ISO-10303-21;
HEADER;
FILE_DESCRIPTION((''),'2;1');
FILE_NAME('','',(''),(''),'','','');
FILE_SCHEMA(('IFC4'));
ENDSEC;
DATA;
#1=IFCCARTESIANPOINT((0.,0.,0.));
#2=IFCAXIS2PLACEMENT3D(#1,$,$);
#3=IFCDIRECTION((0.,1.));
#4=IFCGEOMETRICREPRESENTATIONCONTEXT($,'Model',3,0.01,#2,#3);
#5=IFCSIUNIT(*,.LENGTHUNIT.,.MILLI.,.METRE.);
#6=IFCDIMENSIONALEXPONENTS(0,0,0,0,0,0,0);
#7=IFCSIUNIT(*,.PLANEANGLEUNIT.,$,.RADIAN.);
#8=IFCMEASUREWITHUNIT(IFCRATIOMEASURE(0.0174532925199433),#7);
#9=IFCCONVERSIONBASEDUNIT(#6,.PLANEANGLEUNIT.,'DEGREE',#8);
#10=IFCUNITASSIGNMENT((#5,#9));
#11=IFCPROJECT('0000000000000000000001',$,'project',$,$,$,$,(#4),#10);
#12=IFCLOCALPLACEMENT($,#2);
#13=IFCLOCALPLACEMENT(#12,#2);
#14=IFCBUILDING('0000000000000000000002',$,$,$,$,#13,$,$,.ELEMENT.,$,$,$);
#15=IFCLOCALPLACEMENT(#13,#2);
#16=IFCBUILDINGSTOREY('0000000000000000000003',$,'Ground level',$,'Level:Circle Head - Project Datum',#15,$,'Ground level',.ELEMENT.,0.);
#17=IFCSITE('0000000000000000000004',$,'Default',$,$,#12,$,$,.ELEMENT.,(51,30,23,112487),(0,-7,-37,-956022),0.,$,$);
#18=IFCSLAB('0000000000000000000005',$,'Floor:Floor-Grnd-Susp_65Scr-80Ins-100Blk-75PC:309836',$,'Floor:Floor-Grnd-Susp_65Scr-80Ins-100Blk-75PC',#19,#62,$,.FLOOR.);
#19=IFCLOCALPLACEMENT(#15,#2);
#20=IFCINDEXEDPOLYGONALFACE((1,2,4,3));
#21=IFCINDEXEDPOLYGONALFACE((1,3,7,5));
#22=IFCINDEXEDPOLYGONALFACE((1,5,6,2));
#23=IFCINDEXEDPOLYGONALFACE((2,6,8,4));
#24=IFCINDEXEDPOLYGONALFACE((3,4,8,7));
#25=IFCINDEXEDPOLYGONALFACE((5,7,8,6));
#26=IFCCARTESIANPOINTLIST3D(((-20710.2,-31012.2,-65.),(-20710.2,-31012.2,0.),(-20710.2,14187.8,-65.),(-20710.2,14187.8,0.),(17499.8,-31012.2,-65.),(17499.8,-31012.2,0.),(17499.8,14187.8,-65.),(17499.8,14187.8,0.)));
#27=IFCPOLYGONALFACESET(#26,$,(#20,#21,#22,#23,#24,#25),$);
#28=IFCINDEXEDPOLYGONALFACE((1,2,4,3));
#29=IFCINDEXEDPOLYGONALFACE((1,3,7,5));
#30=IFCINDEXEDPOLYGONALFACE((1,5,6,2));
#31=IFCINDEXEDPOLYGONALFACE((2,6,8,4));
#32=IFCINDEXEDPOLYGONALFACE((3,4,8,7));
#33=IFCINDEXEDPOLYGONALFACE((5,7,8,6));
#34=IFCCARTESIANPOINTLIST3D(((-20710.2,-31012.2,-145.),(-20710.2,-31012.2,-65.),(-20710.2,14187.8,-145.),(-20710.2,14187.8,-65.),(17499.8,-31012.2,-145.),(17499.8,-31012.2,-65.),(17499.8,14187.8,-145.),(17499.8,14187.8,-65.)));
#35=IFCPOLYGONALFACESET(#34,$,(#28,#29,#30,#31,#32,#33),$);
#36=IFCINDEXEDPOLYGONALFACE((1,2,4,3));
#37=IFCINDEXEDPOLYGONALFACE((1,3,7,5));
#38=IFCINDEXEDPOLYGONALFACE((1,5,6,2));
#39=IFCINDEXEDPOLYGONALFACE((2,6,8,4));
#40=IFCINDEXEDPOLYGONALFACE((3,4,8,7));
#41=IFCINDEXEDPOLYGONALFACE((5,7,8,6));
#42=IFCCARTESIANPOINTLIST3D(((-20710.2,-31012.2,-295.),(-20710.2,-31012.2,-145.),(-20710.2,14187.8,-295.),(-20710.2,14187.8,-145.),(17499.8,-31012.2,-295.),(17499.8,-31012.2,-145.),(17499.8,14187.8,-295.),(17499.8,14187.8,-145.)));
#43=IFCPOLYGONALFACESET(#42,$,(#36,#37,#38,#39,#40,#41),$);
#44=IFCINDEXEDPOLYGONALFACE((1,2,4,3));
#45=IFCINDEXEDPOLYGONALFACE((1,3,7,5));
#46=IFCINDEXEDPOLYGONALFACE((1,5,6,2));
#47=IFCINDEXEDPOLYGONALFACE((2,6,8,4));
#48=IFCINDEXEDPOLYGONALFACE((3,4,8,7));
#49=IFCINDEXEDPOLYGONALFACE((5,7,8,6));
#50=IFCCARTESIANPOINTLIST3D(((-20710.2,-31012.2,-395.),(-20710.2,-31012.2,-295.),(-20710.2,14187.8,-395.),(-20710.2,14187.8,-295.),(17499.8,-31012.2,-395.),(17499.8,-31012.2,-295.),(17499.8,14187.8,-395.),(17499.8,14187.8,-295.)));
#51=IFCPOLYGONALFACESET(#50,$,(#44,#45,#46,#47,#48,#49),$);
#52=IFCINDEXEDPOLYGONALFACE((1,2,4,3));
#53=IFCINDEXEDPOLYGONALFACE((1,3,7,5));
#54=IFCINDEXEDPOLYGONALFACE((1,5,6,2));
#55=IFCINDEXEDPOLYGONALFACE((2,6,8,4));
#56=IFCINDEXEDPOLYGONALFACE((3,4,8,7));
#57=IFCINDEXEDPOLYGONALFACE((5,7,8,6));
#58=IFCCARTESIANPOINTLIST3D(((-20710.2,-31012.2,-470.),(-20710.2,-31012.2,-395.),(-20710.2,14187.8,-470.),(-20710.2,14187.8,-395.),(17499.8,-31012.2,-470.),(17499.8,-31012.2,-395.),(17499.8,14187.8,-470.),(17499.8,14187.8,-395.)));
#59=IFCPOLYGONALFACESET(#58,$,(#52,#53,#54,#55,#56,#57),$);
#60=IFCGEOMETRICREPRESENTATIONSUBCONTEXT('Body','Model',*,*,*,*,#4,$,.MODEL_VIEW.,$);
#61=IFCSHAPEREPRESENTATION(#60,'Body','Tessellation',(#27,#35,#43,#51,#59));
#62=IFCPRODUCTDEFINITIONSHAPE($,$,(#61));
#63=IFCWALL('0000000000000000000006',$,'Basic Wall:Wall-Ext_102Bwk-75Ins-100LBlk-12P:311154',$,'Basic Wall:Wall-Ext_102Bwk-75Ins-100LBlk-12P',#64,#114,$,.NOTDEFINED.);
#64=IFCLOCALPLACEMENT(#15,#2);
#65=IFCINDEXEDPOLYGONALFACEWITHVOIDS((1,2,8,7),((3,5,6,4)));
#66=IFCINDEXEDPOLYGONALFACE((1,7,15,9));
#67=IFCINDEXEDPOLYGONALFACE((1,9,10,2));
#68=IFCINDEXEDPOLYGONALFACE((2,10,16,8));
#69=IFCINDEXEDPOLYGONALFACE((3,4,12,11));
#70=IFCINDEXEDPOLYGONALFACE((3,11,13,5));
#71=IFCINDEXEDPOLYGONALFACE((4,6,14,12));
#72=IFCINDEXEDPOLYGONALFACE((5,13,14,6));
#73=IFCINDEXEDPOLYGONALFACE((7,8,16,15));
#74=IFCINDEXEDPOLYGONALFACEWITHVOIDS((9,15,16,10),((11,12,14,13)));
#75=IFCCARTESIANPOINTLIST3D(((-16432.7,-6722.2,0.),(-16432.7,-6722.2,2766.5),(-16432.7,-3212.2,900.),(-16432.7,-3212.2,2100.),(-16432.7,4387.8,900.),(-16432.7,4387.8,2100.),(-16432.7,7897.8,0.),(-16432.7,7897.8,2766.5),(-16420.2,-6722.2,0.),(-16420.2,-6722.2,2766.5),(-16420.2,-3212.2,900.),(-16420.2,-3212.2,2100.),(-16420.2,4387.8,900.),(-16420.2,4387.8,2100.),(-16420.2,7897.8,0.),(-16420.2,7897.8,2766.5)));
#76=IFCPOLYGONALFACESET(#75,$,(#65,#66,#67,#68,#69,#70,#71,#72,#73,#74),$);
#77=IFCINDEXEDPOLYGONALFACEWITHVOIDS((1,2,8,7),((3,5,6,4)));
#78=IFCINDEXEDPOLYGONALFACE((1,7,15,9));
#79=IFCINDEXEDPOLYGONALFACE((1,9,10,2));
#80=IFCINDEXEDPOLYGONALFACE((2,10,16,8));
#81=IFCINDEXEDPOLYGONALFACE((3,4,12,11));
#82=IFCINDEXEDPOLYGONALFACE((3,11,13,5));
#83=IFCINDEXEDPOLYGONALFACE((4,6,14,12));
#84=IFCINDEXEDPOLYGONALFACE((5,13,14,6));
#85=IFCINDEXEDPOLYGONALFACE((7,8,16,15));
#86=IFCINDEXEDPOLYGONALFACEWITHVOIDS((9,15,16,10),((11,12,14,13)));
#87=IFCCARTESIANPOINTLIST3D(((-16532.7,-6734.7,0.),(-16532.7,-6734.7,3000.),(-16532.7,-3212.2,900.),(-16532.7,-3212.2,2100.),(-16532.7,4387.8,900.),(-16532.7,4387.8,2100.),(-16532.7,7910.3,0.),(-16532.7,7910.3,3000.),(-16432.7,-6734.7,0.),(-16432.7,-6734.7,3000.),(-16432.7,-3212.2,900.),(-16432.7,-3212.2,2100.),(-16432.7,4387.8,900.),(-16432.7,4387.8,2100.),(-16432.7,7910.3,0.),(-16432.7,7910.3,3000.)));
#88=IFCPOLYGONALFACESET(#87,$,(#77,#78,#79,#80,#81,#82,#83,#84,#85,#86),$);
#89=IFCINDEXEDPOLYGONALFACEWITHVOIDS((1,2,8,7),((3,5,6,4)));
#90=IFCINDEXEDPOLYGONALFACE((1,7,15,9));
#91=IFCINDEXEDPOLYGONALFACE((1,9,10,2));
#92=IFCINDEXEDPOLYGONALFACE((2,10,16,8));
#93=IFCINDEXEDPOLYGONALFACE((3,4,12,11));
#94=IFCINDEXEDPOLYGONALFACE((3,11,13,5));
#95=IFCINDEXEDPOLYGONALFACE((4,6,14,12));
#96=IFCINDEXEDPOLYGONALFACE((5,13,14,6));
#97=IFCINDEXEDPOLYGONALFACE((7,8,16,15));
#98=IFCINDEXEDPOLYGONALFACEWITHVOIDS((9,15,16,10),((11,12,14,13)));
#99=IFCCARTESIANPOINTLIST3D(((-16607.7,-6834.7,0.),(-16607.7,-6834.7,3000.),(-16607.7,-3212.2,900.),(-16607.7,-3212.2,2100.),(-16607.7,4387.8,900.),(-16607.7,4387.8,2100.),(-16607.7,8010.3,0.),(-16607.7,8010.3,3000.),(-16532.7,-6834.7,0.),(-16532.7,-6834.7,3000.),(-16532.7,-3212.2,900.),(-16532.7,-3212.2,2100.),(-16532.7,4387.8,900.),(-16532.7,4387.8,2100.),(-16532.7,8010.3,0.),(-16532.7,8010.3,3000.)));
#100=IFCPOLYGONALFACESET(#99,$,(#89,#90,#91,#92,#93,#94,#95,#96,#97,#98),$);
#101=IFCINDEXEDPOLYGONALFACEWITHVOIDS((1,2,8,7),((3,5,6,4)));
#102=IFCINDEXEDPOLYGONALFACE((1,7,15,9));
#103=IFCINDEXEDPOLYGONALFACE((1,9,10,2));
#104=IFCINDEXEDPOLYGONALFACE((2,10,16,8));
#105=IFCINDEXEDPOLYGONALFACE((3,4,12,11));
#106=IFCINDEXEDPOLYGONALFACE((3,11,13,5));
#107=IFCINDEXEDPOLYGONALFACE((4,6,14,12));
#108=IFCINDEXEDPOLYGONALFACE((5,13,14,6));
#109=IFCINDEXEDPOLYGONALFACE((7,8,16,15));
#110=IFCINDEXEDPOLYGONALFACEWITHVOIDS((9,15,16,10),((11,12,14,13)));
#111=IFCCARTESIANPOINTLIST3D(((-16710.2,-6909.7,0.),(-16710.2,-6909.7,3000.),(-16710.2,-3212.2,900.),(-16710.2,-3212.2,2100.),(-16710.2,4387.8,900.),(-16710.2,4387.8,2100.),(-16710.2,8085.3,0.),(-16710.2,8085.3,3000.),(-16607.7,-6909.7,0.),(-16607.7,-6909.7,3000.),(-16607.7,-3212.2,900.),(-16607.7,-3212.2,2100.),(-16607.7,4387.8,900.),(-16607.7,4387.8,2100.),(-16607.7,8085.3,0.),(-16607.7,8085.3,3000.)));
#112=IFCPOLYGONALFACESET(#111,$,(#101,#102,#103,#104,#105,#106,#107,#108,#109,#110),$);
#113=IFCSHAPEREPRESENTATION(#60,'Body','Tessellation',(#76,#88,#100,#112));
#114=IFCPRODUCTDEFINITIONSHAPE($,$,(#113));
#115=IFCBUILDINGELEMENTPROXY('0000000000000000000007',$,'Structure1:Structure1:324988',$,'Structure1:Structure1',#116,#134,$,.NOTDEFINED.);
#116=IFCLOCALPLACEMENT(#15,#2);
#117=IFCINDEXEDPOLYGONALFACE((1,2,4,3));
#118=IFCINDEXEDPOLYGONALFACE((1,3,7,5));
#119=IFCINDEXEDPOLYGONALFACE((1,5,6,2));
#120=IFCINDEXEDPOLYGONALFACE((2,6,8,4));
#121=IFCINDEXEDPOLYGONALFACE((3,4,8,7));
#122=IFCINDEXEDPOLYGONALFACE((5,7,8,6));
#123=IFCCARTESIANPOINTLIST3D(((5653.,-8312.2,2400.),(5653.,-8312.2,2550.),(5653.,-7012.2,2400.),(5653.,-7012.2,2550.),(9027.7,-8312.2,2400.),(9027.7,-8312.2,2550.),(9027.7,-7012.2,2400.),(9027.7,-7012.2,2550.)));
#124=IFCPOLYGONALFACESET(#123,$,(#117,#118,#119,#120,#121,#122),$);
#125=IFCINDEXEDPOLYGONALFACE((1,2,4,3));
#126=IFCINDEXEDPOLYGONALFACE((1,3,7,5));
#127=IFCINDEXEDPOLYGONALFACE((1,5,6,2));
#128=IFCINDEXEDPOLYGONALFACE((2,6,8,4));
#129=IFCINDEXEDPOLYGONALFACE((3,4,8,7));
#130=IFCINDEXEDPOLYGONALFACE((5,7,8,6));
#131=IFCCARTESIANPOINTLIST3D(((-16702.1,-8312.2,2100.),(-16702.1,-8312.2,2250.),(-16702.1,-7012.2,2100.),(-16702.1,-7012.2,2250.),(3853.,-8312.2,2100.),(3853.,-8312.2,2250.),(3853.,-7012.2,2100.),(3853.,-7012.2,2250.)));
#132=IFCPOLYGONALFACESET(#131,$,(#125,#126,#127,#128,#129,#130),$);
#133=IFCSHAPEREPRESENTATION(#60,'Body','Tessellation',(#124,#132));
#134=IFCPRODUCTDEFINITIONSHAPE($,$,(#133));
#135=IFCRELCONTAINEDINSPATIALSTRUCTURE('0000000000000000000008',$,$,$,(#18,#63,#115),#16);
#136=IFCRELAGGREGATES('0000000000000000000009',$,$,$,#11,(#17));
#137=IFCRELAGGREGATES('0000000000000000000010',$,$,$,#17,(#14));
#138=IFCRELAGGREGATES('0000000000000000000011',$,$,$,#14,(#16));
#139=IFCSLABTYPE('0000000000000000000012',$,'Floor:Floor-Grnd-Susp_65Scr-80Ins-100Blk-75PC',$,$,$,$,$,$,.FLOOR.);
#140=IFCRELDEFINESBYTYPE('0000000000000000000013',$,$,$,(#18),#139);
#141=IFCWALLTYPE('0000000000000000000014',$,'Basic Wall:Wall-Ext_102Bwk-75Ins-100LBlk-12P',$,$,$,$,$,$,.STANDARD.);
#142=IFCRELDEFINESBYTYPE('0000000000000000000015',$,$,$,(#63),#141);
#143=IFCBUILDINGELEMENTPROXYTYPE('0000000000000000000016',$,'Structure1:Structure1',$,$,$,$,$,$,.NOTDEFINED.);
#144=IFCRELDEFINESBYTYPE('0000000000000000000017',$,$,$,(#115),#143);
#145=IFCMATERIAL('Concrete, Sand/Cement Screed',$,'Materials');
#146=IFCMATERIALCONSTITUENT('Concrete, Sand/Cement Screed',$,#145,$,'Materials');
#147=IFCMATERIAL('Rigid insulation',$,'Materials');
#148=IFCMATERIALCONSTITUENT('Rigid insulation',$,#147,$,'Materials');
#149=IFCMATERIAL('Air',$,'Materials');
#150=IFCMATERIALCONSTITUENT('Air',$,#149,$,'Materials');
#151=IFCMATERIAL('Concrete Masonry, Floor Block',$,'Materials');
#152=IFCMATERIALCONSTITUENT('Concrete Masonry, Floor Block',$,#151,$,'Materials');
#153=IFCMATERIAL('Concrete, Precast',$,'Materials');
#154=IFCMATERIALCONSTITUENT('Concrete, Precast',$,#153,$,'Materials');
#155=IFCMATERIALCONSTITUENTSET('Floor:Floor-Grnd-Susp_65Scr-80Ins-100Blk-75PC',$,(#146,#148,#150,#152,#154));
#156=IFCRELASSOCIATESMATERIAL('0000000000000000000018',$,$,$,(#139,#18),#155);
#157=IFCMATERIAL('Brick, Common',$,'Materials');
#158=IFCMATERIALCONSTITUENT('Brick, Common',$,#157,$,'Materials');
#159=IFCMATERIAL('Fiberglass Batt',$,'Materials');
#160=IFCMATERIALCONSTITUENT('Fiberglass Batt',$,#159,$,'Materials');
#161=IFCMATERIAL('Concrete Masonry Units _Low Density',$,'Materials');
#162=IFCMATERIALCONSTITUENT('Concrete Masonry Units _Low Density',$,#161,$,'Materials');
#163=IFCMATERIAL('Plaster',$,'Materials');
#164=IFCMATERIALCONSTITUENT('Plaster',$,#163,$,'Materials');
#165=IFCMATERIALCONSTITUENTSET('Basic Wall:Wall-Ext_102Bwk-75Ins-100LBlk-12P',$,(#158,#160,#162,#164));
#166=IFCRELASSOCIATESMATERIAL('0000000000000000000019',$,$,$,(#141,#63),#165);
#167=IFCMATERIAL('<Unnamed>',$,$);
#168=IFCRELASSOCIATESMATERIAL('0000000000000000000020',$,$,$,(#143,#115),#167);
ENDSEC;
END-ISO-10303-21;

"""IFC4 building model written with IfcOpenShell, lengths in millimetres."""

from ifc_helpers import new_model, entity, si_unit, converted_unit, direction, frame, origin, place, context, subcontext, project, spatial, indexed_curve, outline, extrude, source, transform, mapped, material, constituent, constituent_set, type_object, type_shapes, element, save


model = new_model("IFC4")

# Units and contexts
model_context = context("Model", 3, precision=0.01, world=origin(), true_north=direction((0.0, 1.0)))
body_context = subcontext(model_context, "Body", "Model", "MODEL_VIEW")
ifc_project = project(units=[si_unit("LENGTHUNIT", "METRE", prefix="MILLI"), converted_unit("PLANEANGLEUNIT", "DEGREE", entity("IfcRatioMeasure", 0.0174532925199433), si_unit("PLANEANGLEUNIT", "RADIAN"), dimensions=[0, 0, 0, 0, 0, 0, 0])], contexts=[model_context])

# Site, building, storey
site_placement = place(None, origin())
site = spatial("IfcSite", under=ifc_project, at=site_placement, Name="Default", CompositionType="ELEMENT", RefLatitude=(51, 30, 23, 112487), RefLongitude=(0, -7, -37, -956022), RefElevation=0.0)
building_placement = place(site_placement, origin())
building = spatial("IfcBuilding", under=site, at=building_placement, CompositionType="ELEMENT")
storey_placement = place(building_placement, origin())
storey = spatial("IfcBuildingStorey", under=building, at=storey_placement, Name="Ground level", ObjectType="Level:Circle Head - Project Datum", LongName="Ground level", CompositionType="ELEMENT", Elevation=0.0)

# Slab
ifc_material_1 = material(Name="Concrete, Sand/Cement Screed", Category="Materials")
ifc_constituent_1 = constituent(ifc_material_1, Name="Concrete, Sand/Cement Screed", Category="Materials")
ifc_material_2 = material(Name="Rigid insulation", Category="Materials")
ifc_constituent_2 = constituent(ifc_material_2, Name="Rigid insulation", Category="Materials")
ifc_material_3 = material(Name="Air", Category="Materials")
ifc_constituent_3 = constituent(ifc_material_3, Name="Air", Category="Materials")
ifc_material_4 = material(Name="Concrete Masonry, Floor Block", Category="Materials")
ifc_constituent_4 = constituent(ifc_material_4, Name="Concrete Masonry, Floor Block", Category="Materials")
ifc_material_5 = material(Name="Concrete, Precast", Category="Materials")
ifc_constituent_5 = constituent(ifc_material_5, Name="Concrete, Precast", Category="Materials")
ifc_constituent_set_1 = constituent_set(constituents=[ifc_constituent_1, ifc_constituent_2, ifc_constituent_3, ifc_constituent_4, ifc_constituent_5], Name="Floor:Floor-Grnd-Susp_65Scr-80Ins-100Blk-75PC")
slab_type = type_object("IfcSlabType", Name="Floor:Floor-Grnd-Susp_65Scr-80Ins-100Blk-75PC", PredefinedType="FLOOR", material=ifc_constituent_set_1)
slab_placement = place(storey_placement, origin())
element("IfcSlab", 1, at=slab_placement, inside=storey, type_object=slab_type, material=ifc_constituent_set_1, Name="Floor:Floor-Grnd-Susp_65Scr-80Ins-100Blk-75PC:309836", ObjectType="Floor:Floor-Grnd-Susp_65Scr-80Ins-100Blk-75PC", PredefinedType="FLOOR", context=body_context, shape_type="SweptSolid", body=[
    extrude(outline(indexed_curve([(-19105.0, -22600.0), (19105.0, -22600.0), (19105.0, 22600.0), (-19105.0, 22600.0), (-19105.0, -22600.0)], self_intersect=False)), frame((-1605.2, -8412.2, -65.0), z_axis=(0.0, 0.0, 1.0), x_axis=(-1.0, 0.0, 0.0)), (0.0, 0.0, 1.0), 65.0),
    extrude(outline(indexed_curve([(-19105.0, -22600.0), (19105.0, -22600.0), (19105.0, 22600.0), (-19105.0, 22600.0), (-19105.0, -22600.0)], self_intersect=False)), frame((-1605.2, -8412.2, -145.0), z_axis=(0.0, 0.0, 1.0), x_axis=(-1.0, 0.0, 0.0)), (0.0, 0.0, 1.0), 80.0),
    extrude(outline(indexed_curve([(-19105.0, -22600.0), (19105.0, -22600.0), (19105.0, 22600.0), (-19105.0, 22600.0), (-19105.0, -22600.0)], self_intersect=False)), frame((-1605.2, -8412.2, -295.0), z_axis=(0.0, 0.0, 1.0), x_axis=(-1.0, 0.0, 0.0)), (0.0, 0.0, 1.0), 150.0),
    extrude(outline(indexed_curve([(-19105.0, -22600.0), (19105.0, -22600.0), (19105.0, 22600.0), (-19105.0, 22600.0), (-19105.0, -22600.0)], self_intersect=False)), frame((-1605.2, -8412.2, -395.0), z_axis=(0.0, 0.0, 1.0), x_axis=(-1.0, 0.0, 0.0)), (0.0, 0.0, 1.0), 100.0),
    extrude(outline(indexed_curve([(-19105.0, -22600.0), (19105.0, -22600.0), (19105.0, 22600.0), (-19105.0, 22600.0), (-19105.0, -22600.0)], self_intersect=False)), frame((-1605.2, -8412.2, -470.0), z_axis=(0.0, 0.0, 1.0), x_axis=(-1.0, 0.0, 0.0)), (0.0, 0.0, 1.0), 75.0),
])

# Wall, opening
ifc_material_6 = material(Name="Brick, Common", Category="Materials")
ifc_constituent_6 = constituent(ifc_material_6, Name="Brick, Common", Category="Materials")
ifc_material_7 = material(Name="Fiberglass Batt", Category="Materials")
ifc_constituent_7 = constituent(ifc_material_7, Name="Fiberglass Batt", Category="Materials")
ifc_material_8 = material(Name="Concrete Masonry Units _Low Density", Category="Materials")
ifc_constituent_8 = constituent(ifc_material_8, Name="Concrete Masonry Units _Low Density", Category="Materials")
ifc_material_9 = material(Name="Plaster", Category="Materials")
ifc_constituent_9 = constituent(ifc_material_9, Name="Plaster", Category="Materials")
ifc_constituent_set_2 = constituent_set(constituents=[ifc_constituent_6, ifc_constituent_7, ifc_constituent_8, ifc_constituent_9], Name="Basic Wall:Wall-Ext_102Bwk-75Ins-100LBlk-12P")
wall_type_1 = type_object("IfcWallType", Name="Basic Wall:Wall-Ext_102Bwk-75Ins-100LBlk-12P", PredefinedType="STANDARD", material=ifc_constituent_set_2)
wall_1_placement = place(storey_placement, frame((-16565.2, -6722.2, 0.0), z_axis=(0.0, 0.0, 1.0), x_axis=(0.0, 1.0, 0.0)))
wall_1 = element("IfcWall", 2, at=wall_1_placement, inside=storey, type_object=wall_type_1, material=ifc_constituent_set_2, Name="Basic Wall:Wall-Ext_102Bwk-75Ins-100LBlk-12P:311154", ObjectType="Basic Wall:Wall-Ext_102Bwk-75Ins-100LBlk-12P", PredefinedType="NOTDEFINED", context=body_context, shape_type="SweptSolid", body=[
    extrude(outline(indexed_curve([(-1383.2, -7310.0), (1383.2, -7310.0), (1383.2, 7310.0), (-1383.2, 7310.0), (-1383.2, -7310.0)], self_intersect=False), holes=[indexed_curve([(-483.2, -3800.0), (-483.3, 3800.0), (716.8, 3800.0), (716.8, -3800.0), (-483.2, -3800.0)], self_intersect=False)]), frame((7310.0, -132.5, 1383.2), z_axis=(0.0, -1.0, 0.0), x_axis=(0.0, 0.0, 1.0)), (0.0, 0.0, 1.0), 12.5),
    extrude(outline(indexed_curve([(-1500.0, -7322.5), (1500.0, -7322.5), (1500.0, 7322.5), (-1500.0, 7322.5), (-1500.0, -7322.5)], self_intersect=False), holes=[indexed_curve([(-600.0, -3800.0), (-600.0, 3800.0), (600.0, 3800.0), (600.0, -3800.0), (-600.0, -3800.0)], self_intersect=False)]), frame((7310.0, -32.5, 1500.0), z_axis=(0.0, -1.0, 0.0), x_axis=(0.0, 0.0, 1.0)), (0.0, 0.0, 1.0), 100.0),
    extrude(outline(indexed_curve([(-1500.0, -7422.5), (1500.0, -7422.5), (1500.0, 7422.5), (-1500.0, 7422.5), (-1500.0, -7422.5)], self_intersect=False), holes=[indexed_curve([(-600.0, -3800.0), (-600.0, 3800.0), (600.0, 3800.0), (600.0, -3800.0), (-600.0, -3800.0)], self_intersect=False)]), frame((7310.0, 42.5, 1500.0), z_axis=(0.0, -1.0, 0.0), x_axis=(0.0, 0.0, 1.0)), (0.0, 0.0, 1.0), 75.0),
    extrude(outline(indexed_curve([(-7497.5, -1500.0), (7497.5, -1500.0), (7497.5, 1500.0), (-7497.5, 1500.0), (-7497.5, -1500.0)], self_intersect=False), holes=[indexed_curve([(3800.0, 600.0), (3800.0, -600.0), (-3800.0, -600.0), (-3800.0, 600.0), (3800.0, 600.0)], self_intersect=False)]), frame((7310.0, 145.0, 1500.0), z_axis=(0.0, -1.0, 0.0), x_axis=(1.0, 0.0, 0.0)), (0.0, 0.0, 1.0), 102.5),
])
opening_1_placement = place(wall_1_placement, frame((3510.0, -145.0, 900.0)))
element("IfcOpeningElement", 3, at=opening_1_placement, cuts=wall_1, PredefinedType="OPENING", context=body_context, shape_type="SweptSolid", body=[
    extrude(outline(indexed_curve([(1200.0, 7600.0), (0.0, 7600.0), (0.0, 0.0), (1200.0, 0.0), (1200.0, 7600.0)], self_intersect=False)), frame((0.0, 0.0, 0.0), z_axis=(0.0, 1.0, 0.0), x_axis=(0.0, 0.0, 1.0)), (0.0, 0.0, 1.0), 290.0),
])

# Building element proxy
ifc_material_10 = material(Name="<Unnamed>")
building_element_proxy_type = type_object("IfcBuildingElementProxyType", Name="Structure1:Structure1", PredefinedType="NOTDEFINED", material=ifc_material_10)
shared_shape = source(origin(), body_context, "Body", "SweptSolid", [
    extrude(outline(indexed_curve([(-1687.4, -650.0), (1687.4, -650.0), (1687.4, 650.0), (-1687.4, 650.0), (-1687.4, -650.0)], self_intersect=False)), frame((7340.3, -7662.2, 2400.0), z_axis=(0.0, 0.0, 1.0), x_axis=(-1.0, 0.0, 0.0)), (0.0, 0.0, 1.0), 150.0),
    extrude(outline(indexed_curve([(-10277.5, -650.0), (10277.5, -650.0), (10277.5, 650.0), (-10277.5, 650.0), (-10277.5, -650.0)], self_intersect=False)), frame((-6424.6, -7662.2, 2100.0), z_axis=(0.0, 0.0, 1.0), x_axis=(-1.0, 0.0, 0.0)), (0.0, 0.0, 1.0), 150.0),
])
type_shapes(building_element_proxy_type, [shared_shape])
proxy_placement = place(storey_placement, origin())
element("IfcBuildingElementProxy", 4, at=proxy_placement, inside=storey, type_object=building_element_proxy_type, material=ifc_material_10, Name="Structure1:Structure1:324988", ObjectType="Structure1:Structure1", PredefinedType="NOTDEFINED", context=body_context, shape_type="MappedRepresentation", body=[
    mapped(shared_shape, transform((0.0, 0.0, 0.0), scale=1.0)),
])

save(model, "model.ifc")
